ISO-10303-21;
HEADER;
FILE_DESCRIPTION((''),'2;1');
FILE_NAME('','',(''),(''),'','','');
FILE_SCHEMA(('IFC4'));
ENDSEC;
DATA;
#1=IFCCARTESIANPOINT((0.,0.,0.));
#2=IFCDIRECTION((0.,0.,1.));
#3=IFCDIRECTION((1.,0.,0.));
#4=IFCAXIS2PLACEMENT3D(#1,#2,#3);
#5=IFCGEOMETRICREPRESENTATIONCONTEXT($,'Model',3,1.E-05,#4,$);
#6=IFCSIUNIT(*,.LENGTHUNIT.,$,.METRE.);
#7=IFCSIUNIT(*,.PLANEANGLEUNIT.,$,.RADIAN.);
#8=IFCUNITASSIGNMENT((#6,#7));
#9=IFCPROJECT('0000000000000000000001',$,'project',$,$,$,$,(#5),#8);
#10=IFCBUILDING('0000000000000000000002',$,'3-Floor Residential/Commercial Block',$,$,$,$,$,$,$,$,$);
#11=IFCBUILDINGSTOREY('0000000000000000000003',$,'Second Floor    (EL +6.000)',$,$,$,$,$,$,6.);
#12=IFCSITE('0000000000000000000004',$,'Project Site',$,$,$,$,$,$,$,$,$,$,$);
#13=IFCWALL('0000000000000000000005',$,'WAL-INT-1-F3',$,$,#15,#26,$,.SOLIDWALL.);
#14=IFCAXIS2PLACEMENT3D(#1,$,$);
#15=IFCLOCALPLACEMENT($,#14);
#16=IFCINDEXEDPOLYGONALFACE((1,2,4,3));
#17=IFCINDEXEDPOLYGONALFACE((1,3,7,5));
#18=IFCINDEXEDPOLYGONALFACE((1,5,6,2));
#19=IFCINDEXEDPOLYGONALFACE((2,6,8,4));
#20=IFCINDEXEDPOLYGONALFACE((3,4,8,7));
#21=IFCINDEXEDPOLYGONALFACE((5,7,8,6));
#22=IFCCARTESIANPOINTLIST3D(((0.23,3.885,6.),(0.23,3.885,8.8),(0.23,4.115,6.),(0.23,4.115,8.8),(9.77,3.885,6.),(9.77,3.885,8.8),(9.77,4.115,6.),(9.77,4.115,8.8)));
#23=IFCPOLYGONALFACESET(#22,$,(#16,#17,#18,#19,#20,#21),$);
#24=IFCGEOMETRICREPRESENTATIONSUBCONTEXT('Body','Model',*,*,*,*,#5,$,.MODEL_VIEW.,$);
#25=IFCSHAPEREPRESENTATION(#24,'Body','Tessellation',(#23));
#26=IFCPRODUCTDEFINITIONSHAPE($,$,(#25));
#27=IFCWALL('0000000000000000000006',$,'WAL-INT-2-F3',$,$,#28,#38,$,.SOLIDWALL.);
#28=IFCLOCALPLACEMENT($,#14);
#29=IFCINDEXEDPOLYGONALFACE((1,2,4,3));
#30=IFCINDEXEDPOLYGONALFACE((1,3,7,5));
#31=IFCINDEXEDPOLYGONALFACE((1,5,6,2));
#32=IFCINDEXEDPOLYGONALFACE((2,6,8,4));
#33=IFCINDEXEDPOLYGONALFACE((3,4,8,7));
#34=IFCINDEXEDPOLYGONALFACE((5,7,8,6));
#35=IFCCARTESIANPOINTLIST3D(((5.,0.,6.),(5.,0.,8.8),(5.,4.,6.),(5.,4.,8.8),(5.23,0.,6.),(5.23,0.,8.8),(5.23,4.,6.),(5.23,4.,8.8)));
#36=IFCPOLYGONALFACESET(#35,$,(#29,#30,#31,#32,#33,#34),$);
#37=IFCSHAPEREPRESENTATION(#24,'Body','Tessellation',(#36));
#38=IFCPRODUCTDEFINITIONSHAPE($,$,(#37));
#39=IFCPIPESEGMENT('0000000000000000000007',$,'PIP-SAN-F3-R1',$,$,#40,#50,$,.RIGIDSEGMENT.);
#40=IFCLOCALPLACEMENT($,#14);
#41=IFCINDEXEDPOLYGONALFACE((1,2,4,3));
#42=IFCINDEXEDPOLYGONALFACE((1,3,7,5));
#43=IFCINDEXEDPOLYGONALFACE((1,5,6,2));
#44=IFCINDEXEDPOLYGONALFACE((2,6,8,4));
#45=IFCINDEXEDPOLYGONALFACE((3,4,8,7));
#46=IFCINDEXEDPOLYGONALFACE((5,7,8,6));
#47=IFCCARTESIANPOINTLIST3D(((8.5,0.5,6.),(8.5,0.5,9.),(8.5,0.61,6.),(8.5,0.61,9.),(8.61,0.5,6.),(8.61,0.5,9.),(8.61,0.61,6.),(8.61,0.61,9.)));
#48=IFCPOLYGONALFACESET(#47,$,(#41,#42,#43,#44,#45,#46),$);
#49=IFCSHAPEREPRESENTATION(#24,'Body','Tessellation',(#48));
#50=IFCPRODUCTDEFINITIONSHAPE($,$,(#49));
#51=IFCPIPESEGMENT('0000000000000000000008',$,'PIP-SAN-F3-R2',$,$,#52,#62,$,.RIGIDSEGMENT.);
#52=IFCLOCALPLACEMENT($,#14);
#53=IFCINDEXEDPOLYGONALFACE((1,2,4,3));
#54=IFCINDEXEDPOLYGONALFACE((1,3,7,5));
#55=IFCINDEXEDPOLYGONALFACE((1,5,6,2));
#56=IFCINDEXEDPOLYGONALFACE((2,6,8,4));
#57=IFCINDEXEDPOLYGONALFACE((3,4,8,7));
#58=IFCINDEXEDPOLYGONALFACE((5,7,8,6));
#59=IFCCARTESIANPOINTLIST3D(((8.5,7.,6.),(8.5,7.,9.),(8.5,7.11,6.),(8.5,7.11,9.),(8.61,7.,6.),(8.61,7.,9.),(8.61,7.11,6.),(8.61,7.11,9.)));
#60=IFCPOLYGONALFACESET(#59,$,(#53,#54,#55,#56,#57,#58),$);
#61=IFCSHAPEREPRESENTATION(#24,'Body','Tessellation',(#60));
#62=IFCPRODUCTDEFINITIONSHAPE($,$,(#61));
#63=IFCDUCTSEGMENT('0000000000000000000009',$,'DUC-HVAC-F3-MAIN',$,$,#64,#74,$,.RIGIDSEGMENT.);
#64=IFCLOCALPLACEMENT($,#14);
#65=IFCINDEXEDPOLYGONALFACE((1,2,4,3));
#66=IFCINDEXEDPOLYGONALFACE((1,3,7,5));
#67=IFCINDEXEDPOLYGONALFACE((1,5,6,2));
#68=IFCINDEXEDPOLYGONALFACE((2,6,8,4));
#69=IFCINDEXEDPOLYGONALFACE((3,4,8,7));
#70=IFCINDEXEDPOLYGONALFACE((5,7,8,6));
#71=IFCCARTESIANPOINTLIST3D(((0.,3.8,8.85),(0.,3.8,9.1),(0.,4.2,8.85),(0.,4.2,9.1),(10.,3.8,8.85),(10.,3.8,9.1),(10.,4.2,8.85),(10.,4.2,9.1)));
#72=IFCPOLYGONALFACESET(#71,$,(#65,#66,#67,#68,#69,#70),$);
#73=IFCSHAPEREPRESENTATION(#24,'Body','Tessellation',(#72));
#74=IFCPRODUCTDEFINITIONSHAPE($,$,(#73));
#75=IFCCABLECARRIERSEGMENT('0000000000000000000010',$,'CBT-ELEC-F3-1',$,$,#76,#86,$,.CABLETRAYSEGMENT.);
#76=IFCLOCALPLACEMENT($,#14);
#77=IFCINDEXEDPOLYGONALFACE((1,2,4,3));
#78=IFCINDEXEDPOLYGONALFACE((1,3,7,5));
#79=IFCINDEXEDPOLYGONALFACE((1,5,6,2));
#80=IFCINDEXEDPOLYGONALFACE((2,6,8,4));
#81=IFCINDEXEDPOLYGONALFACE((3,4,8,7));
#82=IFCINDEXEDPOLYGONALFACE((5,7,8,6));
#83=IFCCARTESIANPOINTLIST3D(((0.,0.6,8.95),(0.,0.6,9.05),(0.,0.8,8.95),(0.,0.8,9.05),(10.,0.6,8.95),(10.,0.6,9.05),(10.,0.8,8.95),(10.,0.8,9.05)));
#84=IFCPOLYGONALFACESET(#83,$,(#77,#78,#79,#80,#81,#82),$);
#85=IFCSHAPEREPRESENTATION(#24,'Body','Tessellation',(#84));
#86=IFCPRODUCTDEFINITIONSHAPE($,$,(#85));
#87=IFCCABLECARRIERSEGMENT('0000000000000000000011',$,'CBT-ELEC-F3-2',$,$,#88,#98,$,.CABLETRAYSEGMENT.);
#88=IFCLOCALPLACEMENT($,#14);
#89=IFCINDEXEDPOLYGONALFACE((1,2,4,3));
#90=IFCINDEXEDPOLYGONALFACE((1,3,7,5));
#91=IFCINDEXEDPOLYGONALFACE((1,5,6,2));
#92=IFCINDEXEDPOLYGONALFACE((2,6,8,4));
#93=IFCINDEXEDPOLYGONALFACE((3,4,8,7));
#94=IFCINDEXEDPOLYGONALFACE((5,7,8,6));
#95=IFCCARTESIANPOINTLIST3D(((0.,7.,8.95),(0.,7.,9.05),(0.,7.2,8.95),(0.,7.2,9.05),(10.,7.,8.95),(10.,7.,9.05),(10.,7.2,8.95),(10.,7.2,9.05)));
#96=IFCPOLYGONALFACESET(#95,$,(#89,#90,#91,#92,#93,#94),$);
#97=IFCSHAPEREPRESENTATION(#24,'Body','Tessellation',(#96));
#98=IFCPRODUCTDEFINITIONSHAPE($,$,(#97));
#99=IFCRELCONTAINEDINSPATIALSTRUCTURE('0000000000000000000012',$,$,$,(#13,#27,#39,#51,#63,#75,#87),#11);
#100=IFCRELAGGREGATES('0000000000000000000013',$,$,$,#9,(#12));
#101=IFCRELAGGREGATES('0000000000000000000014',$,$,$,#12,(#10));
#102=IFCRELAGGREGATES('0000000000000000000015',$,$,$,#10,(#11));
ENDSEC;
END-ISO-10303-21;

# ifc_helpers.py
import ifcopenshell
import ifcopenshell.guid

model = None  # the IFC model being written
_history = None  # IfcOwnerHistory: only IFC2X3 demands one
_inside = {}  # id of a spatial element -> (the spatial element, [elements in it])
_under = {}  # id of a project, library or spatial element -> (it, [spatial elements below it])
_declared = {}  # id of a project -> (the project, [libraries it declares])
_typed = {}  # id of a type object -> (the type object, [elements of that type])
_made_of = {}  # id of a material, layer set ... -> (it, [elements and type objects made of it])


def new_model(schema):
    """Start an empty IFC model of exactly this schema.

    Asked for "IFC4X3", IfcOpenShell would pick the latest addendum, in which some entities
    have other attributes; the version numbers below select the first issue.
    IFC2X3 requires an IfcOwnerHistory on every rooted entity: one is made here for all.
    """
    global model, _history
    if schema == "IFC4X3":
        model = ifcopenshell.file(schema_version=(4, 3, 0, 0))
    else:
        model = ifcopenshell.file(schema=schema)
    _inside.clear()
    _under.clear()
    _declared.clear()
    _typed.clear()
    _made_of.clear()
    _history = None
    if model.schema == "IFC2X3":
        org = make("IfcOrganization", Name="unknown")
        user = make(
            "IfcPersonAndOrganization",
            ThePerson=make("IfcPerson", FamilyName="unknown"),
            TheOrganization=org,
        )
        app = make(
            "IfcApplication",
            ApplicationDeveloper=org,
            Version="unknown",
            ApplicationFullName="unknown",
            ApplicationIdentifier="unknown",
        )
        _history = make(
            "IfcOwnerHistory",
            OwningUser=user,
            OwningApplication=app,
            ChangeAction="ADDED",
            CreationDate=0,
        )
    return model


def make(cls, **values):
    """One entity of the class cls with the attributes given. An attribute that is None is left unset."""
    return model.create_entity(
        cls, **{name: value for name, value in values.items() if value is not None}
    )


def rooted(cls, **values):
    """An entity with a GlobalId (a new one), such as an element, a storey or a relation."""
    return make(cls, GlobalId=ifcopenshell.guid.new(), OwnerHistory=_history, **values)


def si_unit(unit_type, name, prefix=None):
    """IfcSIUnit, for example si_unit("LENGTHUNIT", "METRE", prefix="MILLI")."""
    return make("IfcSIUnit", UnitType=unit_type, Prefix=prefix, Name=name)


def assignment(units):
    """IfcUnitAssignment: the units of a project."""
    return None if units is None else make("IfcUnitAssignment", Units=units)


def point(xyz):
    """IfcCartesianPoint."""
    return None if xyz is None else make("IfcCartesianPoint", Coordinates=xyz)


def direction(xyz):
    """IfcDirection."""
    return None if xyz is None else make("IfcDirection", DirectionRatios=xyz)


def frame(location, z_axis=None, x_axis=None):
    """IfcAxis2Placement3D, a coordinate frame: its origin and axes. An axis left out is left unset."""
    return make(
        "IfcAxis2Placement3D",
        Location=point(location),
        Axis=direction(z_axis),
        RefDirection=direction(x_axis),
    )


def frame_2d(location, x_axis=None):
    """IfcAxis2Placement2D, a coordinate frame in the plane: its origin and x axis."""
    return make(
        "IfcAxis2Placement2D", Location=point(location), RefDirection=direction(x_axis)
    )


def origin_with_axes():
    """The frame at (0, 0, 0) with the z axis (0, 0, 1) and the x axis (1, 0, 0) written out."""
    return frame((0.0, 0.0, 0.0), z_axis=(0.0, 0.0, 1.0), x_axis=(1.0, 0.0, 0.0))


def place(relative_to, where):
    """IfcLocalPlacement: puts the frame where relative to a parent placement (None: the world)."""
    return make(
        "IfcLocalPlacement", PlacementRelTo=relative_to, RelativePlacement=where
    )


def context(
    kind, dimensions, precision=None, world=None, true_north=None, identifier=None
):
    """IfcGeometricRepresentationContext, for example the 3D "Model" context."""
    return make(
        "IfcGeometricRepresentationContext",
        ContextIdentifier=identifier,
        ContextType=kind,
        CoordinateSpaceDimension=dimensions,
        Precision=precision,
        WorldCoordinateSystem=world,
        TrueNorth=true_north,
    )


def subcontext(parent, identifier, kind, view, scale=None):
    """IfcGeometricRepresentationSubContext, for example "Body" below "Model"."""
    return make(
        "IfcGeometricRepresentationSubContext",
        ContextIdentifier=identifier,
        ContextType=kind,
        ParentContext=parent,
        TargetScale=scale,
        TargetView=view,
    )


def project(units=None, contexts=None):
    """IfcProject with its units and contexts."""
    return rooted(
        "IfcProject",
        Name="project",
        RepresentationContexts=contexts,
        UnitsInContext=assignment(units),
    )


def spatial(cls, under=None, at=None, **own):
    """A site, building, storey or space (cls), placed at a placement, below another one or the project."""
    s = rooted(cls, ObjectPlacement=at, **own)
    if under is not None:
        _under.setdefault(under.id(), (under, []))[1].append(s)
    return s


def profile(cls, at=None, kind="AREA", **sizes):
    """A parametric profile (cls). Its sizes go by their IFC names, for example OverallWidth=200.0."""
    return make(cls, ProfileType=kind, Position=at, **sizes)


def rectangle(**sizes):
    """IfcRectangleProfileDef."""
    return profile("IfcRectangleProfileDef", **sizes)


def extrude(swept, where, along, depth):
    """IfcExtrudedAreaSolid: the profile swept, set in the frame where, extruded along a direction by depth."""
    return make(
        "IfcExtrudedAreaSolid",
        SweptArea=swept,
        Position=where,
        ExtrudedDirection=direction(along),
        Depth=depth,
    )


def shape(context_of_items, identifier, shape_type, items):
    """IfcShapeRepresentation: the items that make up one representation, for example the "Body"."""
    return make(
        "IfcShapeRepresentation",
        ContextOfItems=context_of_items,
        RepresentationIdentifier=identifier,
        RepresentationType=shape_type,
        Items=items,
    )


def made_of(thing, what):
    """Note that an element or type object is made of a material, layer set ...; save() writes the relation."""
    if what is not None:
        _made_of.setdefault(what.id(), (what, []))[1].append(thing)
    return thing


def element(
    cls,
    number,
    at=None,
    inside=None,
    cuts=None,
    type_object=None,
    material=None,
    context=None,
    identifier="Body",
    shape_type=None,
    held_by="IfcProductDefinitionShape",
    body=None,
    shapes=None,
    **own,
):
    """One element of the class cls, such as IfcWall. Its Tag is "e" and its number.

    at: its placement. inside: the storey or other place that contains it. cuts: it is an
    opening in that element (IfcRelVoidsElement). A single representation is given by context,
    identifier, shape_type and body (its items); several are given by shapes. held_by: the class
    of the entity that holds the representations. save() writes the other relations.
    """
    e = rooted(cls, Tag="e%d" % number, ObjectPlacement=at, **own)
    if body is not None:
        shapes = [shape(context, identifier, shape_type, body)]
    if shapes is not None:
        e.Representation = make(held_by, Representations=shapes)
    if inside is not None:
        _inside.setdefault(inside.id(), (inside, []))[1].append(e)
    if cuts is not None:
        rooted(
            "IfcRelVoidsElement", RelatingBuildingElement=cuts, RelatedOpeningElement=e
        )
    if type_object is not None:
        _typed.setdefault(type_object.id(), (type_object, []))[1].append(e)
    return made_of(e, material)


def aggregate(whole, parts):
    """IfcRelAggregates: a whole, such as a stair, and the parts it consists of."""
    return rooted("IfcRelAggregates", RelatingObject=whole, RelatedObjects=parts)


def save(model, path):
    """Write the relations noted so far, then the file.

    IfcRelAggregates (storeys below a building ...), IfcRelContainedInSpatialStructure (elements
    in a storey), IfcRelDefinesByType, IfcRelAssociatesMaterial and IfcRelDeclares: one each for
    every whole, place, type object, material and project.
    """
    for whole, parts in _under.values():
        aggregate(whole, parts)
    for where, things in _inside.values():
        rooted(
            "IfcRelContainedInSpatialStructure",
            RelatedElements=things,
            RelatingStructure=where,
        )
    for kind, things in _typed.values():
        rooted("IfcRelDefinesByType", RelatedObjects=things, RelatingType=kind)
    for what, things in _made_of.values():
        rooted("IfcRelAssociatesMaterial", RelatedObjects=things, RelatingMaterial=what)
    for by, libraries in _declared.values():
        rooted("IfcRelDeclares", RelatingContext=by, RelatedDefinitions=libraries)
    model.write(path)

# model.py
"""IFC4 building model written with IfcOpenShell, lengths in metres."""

from ifc_helpers import new_model, si_unit, frame, frame_2d, origin_with_axes, place, context, subcontext, project, spatial, rectangle, extrude, element, save


model = new_model("IFC4")

# Units and contexts
model_context = context("Model", 3, precision=1e-05, world=origin_with_axes())
body_context = subcontext(model_context, "Body", "Model", "MODEL_VIEW")
ifc_project = project(units=[si_unit("LENGTHUNIT", "METRE"), si_unit("PLANEANGLEUNIT", "RADIAN")], contexts=[model_context])

# Site, building, storey
site = spatial("IfcSite", under=ifc_project, Name="Project Site")
building = spatial("IfcBuilding", under=site, Name="3-Floor Residential/Commercial Block")
storey = spatial("IfcBuildingStorey", under=building, Name="Second Floor    (EL +6.000)", Elevation=6.0)

# Walls
wall_1_placement = place(None, frame((0.23, 3.885, 6.0), z_axis=(0.0, 0.0, 1.0), x_axis=(1.0, 0.0, 0.0)))
element("IfcWall", 1, at=wall_1_placement, inside=storey, Name="WAL-INT-1-F3", PredefinedType="SOLIDWALL", context=body_context, shape_type="SweptSolid", body=[
    extrude(rectangle(XDim=9.54, YDim=0.23, at=frame_2d((4.77, 0.115))), origin_with_axes(), (0.0, 0.0, 1.0), 2.8),
])
wall_2_placement = place(None, frame((5.0, 0.0, 6.0), z_axis=(0.0, 0.0, 1.0), x_axis=(1.0, 0.0, 0.0)))
element("IfcWall", 2, at=wall_2_placement, inside=storey, Name="WAL-INT-2-F3", PredefinedType="SOLIDWALL", context=body_context, shape_type="SweptSolid", body=[
    extrude(rectangle(XDim=0.23, YDim=4.0, at=frame_2d((0.115, 2.0))), origin_with_axes(), (0.0, 0.0, 1.0), 2.8),
])

# Pipe segments
for number, where, z_axis, x_axis, name in (
    (3, (8.5, 0.5, 6.0), (0.0, 0.0, 1.0), (1.0, 0.0, 0.0), "PIP-SAN-F3-R1"),
    (4, (8.5, 7.0, 6.0), (0.0, 0.0, 1.0), (1.0, 0.0, 0.0), "PIP-SAN-F3-R2"),
):
    element("IfcPipeSegment", number, at=place(None, frame(where, z_axis=z_axis, x_axis=x_axis)), inside=storey, Name=name, PredefinedType="RIGIDSEGMENT", context=body_context, shape_type="SweptSolid", body=[
        extrude(rectangle(XDim=0.11, YDim=0.11, at=frame_2d((0.055, 0.055))), origin_with_axes(), (0.0, 0.0, 1.0), 3.0),
    ])

# Duct segment
duct_segment_placement = place(None, frame((0.0, 3.8, 8.85), z_axis=(0.0, 0.0, 1.0), x_axis=(1.0, 0.0, 0.0)))
element("IfcDuctSegment", 5, at=duct_segment_placement, inside=storey, Name="DUC-HVAC-F3-MAIN", PredefinedType="RIGIDSEGMENT", context=body_context, shape_type="SweptSolid", body=[
    extrude(rectangle(XDim=10.0, YDim=0.4, at=frame_2d((5.0, 0.2))), origin_with_axes(), (0.0, 0.0, 1.0), 0.25),
])

# Cable carrier segments
for number, where, z_axis, x_axis, name in (
    (6, (0.0, 0.6, 8.95), (0.0, 0.0, 1.0), (1.0, 0.0, 0.0), "CBT-ELEC-F3-1"),
    (7, (0.0, 7.0, 8.95), (0.0, 0.0, 1.0), (1.0, 0.0, 0.0), "CBT-ELEC-F3-2"),
):
    element("IfcCableCarrierSegment", number, at=place(None, frame(where, z_axis=z_axis, x_axis=x_axis)), inside=storey, Name=name, PredefinedType="CABLETRAYSEGMENT", context=body_context, shape_type="SweptSolid", body=[
        extrude(rectangle(XDim=10.0, YDim=0.2, at=frame_2d((5.0, 0.1))), origin_with_axes(), (0.0, 0.0, 1.0), 0.1),
    ])

save(model, "model.ifc")
